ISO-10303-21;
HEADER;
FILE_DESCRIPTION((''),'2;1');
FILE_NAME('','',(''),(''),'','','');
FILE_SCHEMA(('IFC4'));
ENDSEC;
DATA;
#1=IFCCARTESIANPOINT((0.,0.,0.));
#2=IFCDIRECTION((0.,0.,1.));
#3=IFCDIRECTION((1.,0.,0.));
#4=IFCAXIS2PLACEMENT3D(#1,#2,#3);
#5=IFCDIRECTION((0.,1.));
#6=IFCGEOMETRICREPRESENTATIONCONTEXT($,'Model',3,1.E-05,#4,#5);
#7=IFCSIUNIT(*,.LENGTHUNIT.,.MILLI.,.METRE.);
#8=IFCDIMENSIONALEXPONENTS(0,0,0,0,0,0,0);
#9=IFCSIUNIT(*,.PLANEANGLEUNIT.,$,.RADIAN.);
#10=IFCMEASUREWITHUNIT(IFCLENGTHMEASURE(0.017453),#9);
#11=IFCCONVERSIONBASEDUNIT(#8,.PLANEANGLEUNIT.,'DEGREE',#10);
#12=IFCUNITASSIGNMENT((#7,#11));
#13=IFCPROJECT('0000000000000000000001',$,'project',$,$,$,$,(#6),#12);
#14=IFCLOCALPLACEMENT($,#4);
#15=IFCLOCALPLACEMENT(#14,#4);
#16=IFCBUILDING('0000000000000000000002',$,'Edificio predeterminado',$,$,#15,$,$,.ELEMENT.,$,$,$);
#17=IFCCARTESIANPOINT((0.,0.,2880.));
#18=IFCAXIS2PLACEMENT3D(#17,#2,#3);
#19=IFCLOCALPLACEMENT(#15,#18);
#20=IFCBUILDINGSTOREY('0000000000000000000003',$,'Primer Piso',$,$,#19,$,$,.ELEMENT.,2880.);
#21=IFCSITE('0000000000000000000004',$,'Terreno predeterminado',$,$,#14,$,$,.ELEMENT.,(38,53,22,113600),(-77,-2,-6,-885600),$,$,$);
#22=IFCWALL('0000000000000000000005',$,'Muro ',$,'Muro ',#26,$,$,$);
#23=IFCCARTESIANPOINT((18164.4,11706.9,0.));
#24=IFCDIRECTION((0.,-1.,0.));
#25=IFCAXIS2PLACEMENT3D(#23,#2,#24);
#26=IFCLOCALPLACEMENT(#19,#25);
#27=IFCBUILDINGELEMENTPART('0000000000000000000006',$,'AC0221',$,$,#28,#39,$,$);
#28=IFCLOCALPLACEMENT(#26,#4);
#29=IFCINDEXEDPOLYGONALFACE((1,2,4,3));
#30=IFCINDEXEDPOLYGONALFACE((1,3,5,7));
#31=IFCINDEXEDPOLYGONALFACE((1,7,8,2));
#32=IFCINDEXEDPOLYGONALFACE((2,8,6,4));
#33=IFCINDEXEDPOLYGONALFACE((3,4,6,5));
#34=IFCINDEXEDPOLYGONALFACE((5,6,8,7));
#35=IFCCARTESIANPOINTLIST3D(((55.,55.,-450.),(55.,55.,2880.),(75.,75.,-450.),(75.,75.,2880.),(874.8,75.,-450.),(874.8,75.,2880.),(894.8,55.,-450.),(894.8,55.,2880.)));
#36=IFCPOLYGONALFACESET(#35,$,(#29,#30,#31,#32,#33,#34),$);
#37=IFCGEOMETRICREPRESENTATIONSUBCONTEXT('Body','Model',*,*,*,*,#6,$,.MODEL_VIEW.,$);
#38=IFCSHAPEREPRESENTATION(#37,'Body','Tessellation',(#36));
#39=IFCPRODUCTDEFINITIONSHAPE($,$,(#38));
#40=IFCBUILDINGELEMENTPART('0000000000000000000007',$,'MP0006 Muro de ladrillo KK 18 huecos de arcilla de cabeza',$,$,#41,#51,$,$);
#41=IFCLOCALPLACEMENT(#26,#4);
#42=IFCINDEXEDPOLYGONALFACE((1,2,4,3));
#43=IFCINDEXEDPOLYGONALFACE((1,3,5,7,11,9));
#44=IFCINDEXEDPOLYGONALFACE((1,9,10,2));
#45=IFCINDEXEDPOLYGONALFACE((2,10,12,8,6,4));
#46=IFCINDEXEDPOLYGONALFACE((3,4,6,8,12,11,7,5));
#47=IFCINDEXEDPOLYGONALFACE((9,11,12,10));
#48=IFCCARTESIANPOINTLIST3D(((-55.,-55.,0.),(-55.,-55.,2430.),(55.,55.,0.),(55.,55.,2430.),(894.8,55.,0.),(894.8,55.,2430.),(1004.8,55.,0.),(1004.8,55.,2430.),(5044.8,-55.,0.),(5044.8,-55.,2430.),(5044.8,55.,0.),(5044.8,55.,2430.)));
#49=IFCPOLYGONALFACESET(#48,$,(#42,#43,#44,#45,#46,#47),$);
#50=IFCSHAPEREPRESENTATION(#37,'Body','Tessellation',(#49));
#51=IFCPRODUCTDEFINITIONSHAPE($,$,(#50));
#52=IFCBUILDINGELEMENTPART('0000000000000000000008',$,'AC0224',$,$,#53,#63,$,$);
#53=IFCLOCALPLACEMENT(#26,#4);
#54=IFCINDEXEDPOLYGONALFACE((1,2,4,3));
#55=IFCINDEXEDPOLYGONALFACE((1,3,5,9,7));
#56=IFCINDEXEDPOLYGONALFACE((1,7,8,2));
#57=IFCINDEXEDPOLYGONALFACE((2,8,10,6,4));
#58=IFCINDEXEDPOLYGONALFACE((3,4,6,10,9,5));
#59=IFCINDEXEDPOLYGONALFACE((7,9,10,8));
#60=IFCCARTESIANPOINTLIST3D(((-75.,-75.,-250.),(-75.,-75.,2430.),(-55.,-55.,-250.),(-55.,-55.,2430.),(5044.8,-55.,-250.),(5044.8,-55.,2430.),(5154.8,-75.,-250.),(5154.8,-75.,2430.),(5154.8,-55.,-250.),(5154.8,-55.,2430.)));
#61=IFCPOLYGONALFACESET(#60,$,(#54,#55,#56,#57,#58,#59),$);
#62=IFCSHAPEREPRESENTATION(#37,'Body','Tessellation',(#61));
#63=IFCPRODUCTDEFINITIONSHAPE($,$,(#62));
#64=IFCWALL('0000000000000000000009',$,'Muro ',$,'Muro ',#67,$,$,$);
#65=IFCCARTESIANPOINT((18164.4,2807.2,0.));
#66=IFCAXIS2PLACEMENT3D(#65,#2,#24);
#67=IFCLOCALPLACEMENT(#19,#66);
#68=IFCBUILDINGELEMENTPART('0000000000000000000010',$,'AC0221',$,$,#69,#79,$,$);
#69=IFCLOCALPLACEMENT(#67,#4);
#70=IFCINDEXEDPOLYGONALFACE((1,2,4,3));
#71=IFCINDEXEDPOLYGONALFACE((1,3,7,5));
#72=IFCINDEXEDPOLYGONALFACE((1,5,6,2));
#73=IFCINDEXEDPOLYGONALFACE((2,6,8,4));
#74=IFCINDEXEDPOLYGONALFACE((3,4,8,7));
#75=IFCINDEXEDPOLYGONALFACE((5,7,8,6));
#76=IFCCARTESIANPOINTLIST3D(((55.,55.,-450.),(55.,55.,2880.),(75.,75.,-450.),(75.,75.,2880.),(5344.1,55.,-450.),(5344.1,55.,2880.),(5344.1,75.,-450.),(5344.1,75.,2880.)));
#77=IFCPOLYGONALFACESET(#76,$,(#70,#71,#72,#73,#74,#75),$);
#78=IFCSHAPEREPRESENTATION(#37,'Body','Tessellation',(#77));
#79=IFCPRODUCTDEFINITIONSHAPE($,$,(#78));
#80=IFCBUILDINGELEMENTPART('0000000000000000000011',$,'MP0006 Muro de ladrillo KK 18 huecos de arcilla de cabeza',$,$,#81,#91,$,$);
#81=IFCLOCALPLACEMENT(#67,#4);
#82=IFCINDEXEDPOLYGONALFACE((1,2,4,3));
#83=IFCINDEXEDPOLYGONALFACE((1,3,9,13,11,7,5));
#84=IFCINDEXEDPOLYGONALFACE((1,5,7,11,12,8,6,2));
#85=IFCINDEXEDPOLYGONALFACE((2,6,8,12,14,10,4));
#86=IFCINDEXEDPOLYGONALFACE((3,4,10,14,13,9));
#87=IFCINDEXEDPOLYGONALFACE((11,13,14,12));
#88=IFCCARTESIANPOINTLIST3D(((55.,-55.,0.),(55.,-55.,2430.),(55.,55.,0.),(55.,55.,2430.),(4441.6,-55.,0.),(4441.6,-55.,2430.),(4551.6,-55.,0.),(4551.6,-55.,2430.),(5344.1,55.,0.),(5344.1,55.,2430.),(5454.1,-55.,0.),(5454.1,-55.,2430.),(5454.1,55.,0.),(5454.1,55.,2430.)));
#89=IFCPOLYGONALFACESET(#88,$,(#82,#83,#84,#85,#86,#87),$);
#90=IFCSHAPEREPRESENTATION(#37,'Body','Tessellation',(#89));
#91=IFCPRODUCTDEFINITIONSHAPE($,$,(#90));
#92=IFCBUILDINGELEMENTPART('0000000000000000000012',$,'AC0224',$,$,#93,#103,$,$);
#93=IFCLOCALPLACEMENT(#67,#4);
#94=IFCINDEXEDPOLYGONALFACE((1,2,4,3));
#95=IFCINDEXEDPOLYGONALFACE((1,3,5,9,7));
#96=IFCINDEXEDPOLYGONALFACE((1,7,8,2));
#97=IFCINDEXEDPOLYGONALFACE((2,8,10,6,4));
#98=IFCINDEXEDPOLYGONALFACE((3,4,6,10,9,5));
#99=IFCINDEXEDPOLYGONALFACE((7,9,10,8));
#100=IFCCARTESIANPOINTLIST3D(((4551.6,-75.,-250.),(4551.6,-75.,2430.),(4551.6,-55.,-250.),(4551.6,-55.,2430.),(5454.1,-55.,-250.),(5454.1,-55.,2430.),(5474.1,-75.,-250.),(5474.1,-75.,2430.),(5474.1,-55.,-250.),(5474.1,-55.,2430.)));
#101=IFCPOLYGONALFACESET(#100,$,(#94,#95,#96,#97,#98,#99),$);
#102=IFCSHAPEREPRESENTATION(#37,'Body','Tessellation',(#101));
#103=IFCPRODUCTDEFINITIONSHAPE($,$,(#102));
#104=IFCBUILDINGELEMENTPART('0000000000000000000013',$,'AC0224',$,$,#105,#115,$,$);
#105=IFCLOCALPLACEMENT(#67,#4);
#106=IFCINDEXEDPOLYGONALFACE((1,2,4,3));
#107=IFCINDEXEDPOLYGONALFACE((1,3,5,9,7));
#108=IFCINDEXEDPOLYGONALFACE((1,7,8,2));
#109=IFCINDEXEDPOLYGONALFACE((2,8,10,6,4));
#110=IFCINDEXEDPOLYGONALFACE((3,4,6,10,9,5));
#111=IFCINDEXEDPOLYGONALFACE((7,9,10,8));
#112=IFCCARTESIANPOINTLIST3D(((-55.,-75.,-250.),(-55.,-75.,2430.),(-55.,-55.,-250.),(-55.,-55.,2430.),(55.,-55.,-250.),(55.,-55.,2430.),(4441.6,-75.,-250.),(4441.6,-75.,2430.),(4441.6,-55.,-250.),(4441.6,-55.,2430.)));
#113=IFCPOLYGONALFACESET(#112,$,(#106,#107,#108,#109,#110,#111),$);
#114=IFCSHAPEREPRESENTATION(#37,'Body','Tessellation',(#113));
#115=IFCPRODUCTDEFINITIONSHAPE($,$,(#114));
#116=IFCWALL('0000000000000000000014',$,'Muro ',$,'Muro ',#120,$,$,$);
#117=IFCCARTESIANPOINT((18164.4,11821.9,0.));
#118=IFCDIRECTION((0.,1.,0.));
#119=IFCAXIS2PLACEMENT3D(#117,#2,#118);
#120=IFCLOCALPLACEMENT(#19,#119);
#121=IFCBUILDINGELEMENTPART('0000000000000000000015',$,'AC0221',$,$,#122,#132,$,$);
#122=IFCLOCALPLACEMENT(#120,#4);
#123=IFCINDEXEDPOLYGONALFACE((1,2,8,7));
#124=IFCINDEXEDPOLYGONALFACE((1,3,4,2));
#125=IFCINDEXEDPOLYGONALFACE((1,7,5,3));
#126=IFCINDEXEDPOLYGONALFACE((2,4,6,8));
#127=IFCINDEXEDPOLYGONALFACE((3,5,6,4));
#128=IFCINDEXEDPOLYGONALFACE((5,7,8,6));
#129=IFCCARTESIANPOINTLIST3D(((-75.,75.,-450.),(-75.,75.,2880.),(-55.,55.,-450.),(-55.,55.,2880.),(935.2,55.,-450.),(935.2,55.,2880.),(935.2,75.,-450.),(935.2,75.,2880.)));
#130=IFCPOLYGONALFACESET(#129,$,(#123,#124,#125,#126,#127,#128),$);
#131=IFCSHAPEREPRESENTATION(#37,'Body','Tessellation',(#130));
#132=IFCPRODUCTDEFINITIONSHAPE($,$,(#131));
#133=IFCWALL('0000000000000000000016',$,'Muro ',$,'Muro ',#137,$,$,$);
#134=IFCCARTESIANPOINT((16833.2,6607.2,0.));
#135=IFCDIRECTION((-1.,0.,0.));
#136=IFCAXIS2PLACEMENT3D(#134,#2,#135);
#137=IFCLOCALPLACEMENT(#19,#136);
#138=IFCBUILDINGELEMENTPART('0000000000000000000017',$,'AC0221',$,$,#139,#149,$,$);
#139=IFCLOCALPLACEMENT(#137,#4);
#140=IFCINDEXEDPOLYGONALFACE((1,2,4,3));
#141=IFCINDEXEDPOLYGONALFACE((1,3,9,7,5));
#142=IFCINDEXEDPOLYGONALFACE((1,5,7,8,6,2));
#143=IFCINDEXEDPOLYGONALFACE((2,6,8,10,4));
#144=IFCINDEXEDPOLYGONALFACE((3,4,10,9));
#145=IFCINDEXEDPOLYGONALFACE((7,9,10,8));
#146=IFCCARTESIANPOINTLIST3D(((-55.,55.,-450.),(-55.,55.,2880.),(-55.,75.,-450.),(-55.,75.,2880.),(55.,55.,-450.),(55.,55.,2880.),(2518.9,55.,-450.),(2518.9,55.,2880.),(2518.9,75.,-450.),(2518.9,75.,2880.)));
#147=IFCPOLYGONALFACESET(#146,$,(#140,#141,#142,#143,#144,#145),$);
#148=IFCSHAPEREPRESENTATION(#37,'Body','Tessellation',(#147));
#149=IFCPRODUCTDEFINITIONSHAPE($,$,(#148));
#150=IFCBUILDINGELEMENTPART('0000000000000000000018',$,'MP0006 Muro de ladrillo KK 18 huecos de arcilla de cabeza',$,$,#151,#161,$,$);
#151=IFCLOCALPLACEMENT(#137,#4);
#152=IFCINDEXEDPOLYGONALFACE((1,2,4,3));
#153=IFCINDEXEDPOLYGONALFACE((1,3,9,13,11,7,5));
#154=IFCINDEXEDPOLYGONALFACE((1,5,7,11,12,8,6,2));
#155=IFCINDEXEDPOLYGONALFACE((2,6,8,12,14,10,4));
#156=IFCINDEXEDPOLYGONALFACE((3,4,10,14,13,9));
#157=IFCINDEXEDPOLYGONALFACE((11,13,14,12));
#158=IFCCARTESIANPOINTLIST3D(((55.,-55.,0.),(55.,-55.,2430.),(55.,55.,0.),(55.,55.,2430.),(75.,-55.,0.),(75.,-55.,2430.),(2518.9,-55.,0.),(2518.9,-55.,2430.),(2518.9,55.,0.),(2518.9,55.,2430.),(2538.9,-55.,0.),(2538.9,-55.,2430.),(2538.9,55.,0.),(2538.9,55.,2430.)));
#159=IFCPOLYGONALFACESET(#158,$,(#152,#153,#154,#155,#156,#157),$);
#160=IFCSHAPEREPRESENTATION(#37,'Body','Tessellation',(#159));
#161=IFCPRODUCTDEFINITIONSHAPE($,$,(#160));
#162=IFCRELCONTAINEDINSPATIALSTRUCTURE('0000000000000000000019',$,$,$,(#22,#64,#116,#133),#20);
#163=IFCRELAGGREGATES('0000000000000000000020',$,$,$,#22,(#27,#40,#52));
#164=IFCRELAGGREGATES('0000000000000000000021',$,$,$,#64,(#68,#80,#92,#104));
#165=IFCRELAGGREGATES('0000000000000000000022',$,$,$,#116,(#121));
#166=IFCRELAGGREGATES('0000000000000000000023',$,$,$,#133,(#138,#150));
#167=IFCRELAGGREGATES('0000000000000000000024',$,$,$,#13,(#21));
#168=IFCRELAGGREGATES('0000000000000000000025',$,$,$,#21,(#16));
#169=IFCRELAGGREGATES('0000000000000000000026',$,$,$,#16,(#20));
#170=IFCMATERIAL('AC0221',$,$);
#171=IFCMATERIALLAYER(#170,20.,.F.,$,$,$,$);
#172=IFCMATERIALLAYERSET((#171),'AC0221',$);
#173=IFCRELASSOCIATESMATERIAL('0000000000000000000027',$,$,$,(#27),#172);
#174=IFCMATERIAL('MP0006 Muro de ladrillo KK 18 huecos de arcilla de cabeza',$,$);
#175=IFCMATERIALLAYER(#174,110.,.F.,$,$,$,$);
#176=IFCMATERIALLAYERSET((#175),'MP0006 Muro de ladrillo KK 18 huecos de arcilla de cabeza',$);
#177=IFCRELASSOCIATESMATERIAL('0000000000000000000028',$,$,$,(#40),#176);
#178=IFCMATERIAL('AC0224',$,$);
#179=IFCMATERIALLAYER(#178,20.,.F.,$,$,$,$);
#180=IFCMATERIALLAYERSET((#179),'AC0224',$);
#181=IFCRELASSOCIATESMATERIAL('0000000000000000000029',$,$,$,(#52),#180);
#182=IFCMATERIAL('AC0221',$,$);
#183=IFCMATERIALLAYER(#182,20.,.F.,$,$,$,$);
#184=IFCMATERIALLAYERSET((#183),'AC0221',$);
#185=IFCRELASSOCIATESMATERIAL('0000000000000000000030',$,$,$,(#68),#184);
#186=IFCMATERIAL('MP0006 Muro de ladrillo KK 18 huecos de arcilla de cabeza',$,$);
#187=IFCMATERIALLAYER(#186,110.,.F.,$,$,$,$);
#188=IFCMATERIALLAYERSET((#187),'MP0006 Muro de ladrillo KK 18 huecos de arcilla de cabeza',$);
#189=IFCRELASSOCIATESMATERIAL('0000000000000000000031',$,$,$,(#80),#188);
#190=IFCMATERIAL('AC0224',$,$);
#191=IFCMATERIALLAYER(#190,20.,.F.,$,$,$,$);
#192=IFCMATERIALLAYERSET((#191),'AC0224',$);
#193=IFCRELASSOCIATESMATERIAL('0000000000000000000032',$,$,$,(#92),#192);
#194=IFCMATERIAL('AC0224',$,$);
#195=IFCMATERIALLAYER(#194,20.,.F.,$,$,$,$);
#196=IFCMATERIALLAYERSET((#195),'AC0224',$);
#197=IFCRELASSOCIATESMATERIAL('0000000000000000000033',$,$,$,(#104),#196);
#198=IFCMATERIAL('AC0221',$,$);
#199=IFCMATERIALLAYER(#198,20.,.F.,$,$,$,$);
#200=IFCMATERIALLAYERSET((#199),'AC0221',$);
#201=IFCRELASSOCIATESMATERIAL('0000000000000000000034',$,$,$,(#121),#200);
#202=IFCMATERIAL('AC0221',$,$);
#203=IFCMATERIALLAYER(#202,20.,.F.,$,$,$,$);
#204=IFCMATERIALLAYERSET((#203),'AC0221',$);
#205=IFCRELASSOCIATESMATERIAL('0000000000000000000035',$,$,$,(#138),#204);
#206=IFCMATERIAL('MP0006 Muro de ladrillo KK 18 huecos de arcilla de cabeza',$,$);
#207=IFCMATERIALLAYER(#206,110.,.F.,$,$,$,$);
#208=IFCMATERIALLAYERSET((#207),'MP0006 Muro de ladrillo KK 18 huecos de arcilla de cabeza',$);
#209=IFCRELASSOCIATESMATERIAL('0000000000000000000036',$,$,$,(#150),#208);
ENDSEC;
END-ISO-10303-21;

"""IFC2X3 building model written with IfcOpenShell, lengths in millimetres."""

from ifc_helpers import new_model, entity, si_unit, converted_unit, direction, frame, origin_with_axes, place, context, subcontext, project, spatial, polyline, outline, extrude, material, layer, layer_set, layer_usage, element, aggregate, save


model = new_model("IFC2X3")

# Units and contexts
model_context = context("Model", 3, precision=1e-05, world=origin_with_axes(), true_north=direction((0.0, 1.0)))
body_context = subcontext(model_context, "Body", "Model", "MODEL_VIEW")
ifc_project = project(units=[si_unit("LENGTHUNIT", "METRE", prefix="MILLI"), converted_unit("PLANEANGLEUNIT", "DEGREE", entity("IfcLengthMeasure", 0.017453), si_unit("PLANEANGLEUNIT", "RADIAN"), dimensions=[0, 0, 0, 0, 0, 0, 0])], contexts=[model_context])

# Site, building, storey
site_placement = place(None, origin_with_axes())
site = spatial("IfcSite", under=ifc_project, at=site_placement, Name="Terreno predeterminado", CompositionType="ELEMENT", RefLatitude=(38, 53, 22, 113600), RefLongitude=(-77, -2, -6, -885600))
building_placement = place(site_placement, origin_with_axes())
building = spatial("IfcBuilding", under=site, at=building_placement, Name="Edificio predeterminado", CompositionType="ELEMENT")
storey_placement = place(building_placement, frame((0.0, 0.0, 2880.0), z_axis=(0.0, 0.0, 1.0), x_axis=(1.0, 0.0, 0.0)))
storey = spatial("IfcBuildingStorey", under=building, at=storey_placement, Name="Primer Piso", CompositionType="ELEMENT", Elevation=2880.0)

# Walls, building element parts
wall_1_placement = place(storey_placement, frame((18164.4, 11706.9, 0.0), z_axis=(0.0, 0.0, 1.0), x_axis=(0.0, -1.0, 0.0)))
wall_1 = element("IfcWall", 1, at=wall_1_placement, inside=storey, Name="Muro ", ObjectType="Muro ")
ifc_material_1 = material(Name="AC0221")
ifc_layer_1 = layer(ifc_material_1, 20.0, ventilated=False)
ifc_layer_set_1 = layer_set([ifc_layer_1], Name="AC0221")
ifc_layer_usage_1 = layer_usage(ifc_layer_set_1, "AXIS2", "NEGATIVE", -75.0)
building_element_part_1_placement = place(wall_1_placement, origin_with_axes())
building_element_part_1 = element("IfcBuildingElementPart", 2, at=building_element_part_1_placement, material=ifc_layer_usage_1, Name="AC0221", context=body_context, shape_type="SweptSolid", body=[
    extrude(outline(polyline([(874.8, 75.0), (894.8, 55.0), (55.0, 55.0), (75.0, 75.0), (874.8, 75.0)])), frame((0.0, 0.0, -450.0), z_axis=(0.0, 0.0, 1.0), x_axis=(1.0, 0.0, 0.0)), (0.0, 0.0, 1.0), 3330.0),
])
ifc_material_2 = material(Name="MP0006 Muro de ladrillo KK 18 huecos de arcilla de cabeza")
ifc_layer_2 = layer(ifc_material_2, 110.0, ventilated=False)
ifc_layer_set_2 = layer_set([ifc_layer_2], Name="MP0006 Muro de ladrillo KK 18 huecos de arcilla de cabeza")
ifc_layer_usage_2 = layer_usage(ifc_layer_set_2, "AXIS2", "NEGATIVE", -55.0)
building_element_part_2_placement = place(wall_1_placement, origin_with_axes())
building_element_part_2 = element("IfcBuildingElementPart", 3, at=building_element_part_2_placement, material=ifc_layer_usage_2, Name="MP0006 Muro de ladrillo KK 18 huecos de arcilla de cabeza", context=body_context, shape_type="SweptSolid", body=[
    extrude(outline(polyline([(5044.8, 55.0), (5044.8, -55.0), (-55.0, -55.0), (55.0, 55.0), (894.8, 55.0), (1004.8, 55.0), (5044.8, 55.0)])), origin_with_axes(), (0.0, 0.0, 1.0), 2430.0),
])
ifc_material_3 = material(Name="AC0224")
ifc_layer_3 = layer(ifc_material_3, 20.0, ventilated=False)
ifc_layer_set_3 = layer_set([ifc_layer_3], Name="AC0224")
ifc_layer_usage_3 = layer_usage(ifc_layer_set_3, "AXIS2", "NEGATIVE", 55.0)
building_element_part_3_placement = place(wall_1_placement, origin_with_axes())
building_element_part_3 = element("IfcBuildingElementPart", 4, at=building_element_part_3_placement, material=ifc_layer_usage_3, Name="AC0224", context=body_context, shape_type="SweptSolid", body=[
    extrude(outline(polyline([(5154.8, -55.0), (5154.8, -75.0), (-75.0, -75.0), (-55.0, -55.0), (5044.8, -55.0), (5154.8, -55.0)])), frame((0.0, 0.0, -250.0), z_axis=(0.0, 0.0, 1.0), x_axis=(1.0, 0.0, 0.0)), (0.0, 0.0, 1.0), 2680.0),
])
aggregate(wall_1, [building_element_part_1, building_element_part_2, building_element_part_3])
wall_2_placement = place(storey_placement, frame((18164.4, 2807.2, 0.0), z_axis=(0.0, 0.0, 1.0), x_axis=(0.0, -1.0, 0.0)))
wall_2 = element("IfcWall", 5, at=wall_2_placement, inside=storey, Name="Muro ", ObjectType="Muro ")
ifc_material_4 = material(Name="AC0221")
ifc_layer_4 = layer(ifc_material_4, 20.0, ventilated=False)
ifc_layer_set_4 = layer_set([ifc_layer_4], Name="AC0221")
ifc_layer_usage_4 = layer_usage(ifc_layer_set_4, "AXIS2", "NEGATIVE", -75.0)
building_element_part_4_placement = place(wall_2_placement, origin_with_axes())
building_element_part_4 = element("IfcBuildingElementPart", 6, at=building_element_part_4_placement, material=ifc_layer_usage_4, Name="AC0221", context=body_context, shape_type="SweptSolid", body=[
    extrude(outline(polyline([(5344.1, 75.0), (5344.1, 55.0), (55.0, 55.0), (75.0, 75.0), (5344.1, 75.0)])), frame((0.0, 0.0, -450.0), z_axis=(0.0, 0.0, 1.0), x_axis=(1.0, 0.0, 0.0)), (0.0, 0.0, 1.0), 3330.0),
])
ifc_material_5 = material(Name="MP0006 Muro de ladrillo KK 18 huecos de arcilla de cabeza")
ifc_layer_5 = layer(ifc_material_5, 110.0, ventilated=False)
ifc_layer_set_5 = layer_set([ifc_layer_5], Name="MP0006 Muro de ladrillo KK 18 huecos de arcilla de cabeza")
ifc_layer_usage_5 = layer_usage(ifc_layer_set_5, "AXIS2", "NEGATIVE", -55.0)
building_element_part_5_placement = place(wall_2_placement, origin_with_axes())
building_element_part_5 = element("IfcBuildingElementPart", 7, at=building_element_part_5_placement, material=ifc_layer_usage_5, Name="MP0006 Muro de ladrillo KK 18 huecos de arcilla de cabeza", context=body_context, shape_type="SweptSolid", body=[
    extrude(outline(polyline([(5454.1, 55.0), (5454.1, -55.0), (4551.6, -55.0), (4441.6, -55.0), (55.0, -55.0), (55.0, 55.0), (5344.1, 55.0), (5454.1, 55.0)])), origin_with_axes(), (0.0, 0.0, 1.0), 2430.0),
])
ifc_material_6 = material(Name="AC0224")
ifc_layer_6 = layer(ifc_material_6, 20.0, ventilated=False)
ifc_layer_set_6 = layer_set([ifc_layer_6], Name="AC0224")
ifc_layer_usage_6 = layer_usage(ifc_layer_set_6, "AXIS2", "NEGATIVE", 55.0)
building_element_part_6_placement = place(wall_2_placement, origin_with_axes())
building_element_part_6 = element("IfcBuildingElementPart", 8, at=building_element_part_6_placement, material=ifc_layer_usage_6, Name="AC0224", context=body_context, shape_type="SweptSolid", body=[
    extrude(outline(polyline([(5474.1, -55.0), (5474.1, -75.0), (4551.6, -75.0), (4551.6, -55.0), (5454.1, -55.0), (5474.1, -55.0)])), frame((0.0, 0.0, -250.0), z_axis=(0.0, 0.0, 1.0), x_axis=(1.0, 0.0, 0.0)), (0.0, 0.0, 1.0), 2680.0),
])
ifc_material_7 = material(Name="AC0224")
ifc_layer_7 = layer(ifc_material_7, 20.0, ventilated=False)
ifc_layer_set_7 = layer_set([ifc_layer_7], Name="AC0224")
ifc_layer_usage_7 = layer_usage(ifc_layer_set_7, "AXIS2", "NEGATIVE", 55.0)
building_element_part_7_placement = place(wall_2_placement, origin_with_axes())
building_element_part_7 = element("IfcBuildingElementPart", 9, at=building_element_part_7_placement, material=ifc_layer_usage_7, Name="AC0224", context=body_context, shape_type="SweptSolid", body=[
    extrude(outline(polyline([(4441.6, -55.0), (4441.6, -75.0), (-55.0, -75.0), (-55.0, -55.0), (55.0, -55.0), (4441.6, -55.0)])), frame((0.0, 0.0, -250.0), z_axis=(0.0, 0.0, 1.0), x_axis=(1.0, 0.0, 0.0)), (0.0, 0.0, 1.0), 2680.0),
])
aggregate(wall_2, [building_element_part_4, building_element_part_5, building_element_part_6, building_element_part_7])

# Wall, building element part
wall_3_placement = place(storey_placement, frame((18164.4, 11821.9, 0.0), z_axis=(0.0, 0.0, 1.0), x_axis=(0.0, 1.0, 0.0)))
wall_3 = element("IfcWall", 10, at=wall_3_placement, inside=storey, Name="Muro ", ObjectType="Muro ")
ifc_material_8 = material(Name="AC0221")
ifc_layer_8 = layer(ifc_material_8, 20.0, ventilated=False)
ifc_layer_set_8 = layer_set([ifc_layer_8], Name="AC0221")
ifc_layer_usage_8 = layer_usage(ifc_layer_set_8, "AXIS2", "NEGATIVE", -75.0)
building_element_part_8_placement = place(wall_3_placement, origin_with_axes())
building_element_part_8 = element("IfcBuildingElementPart", 11, at=building_element_part_8_placement, material=ifc_layer_usage_8, Name="AC0221", context=body_context, shape_type="SweptSolid", body=[
    extrude(outline(polyline([(935.2, 75.0), (935.2, 55.0), (-55.0, 55.0), (-75.0, 75.0), (935.2, 75.0)])), frame((0.0, 0.0, -450.0), z_axis=(0.0, 0.0, 1.0), x_axis=(1.0, 0.0, 0.0)), (0.0, 0.0, 1.0), 3330.0),
])
aggregate(wall_3, [building_element_part_8])

# Wall, building element parts
wall_4_placement = place(storey_placement, frame((16833.2, 6607.2, 0.0), z_axis=(0.0, 0.0, 1.0), x_axis=(-1.0, 0.0, 0.0)))
wall_4 = element("IfcWall", 12, at=wall_4_placement, inside=storey, Name="Muro ", ObjectType="Muro ")
ifc_material_9 = material(Name="AC0221")
ifc_layer_9 = layer(ifc_material_9, 20.0, ventilated=False)
ifc_layer_set_9 = layer_set([ifc_layer_9], Name="AC0221")
ifc_layer_usage_9 = layer_usage(ifc_layer_set_9, "AXIS2", "NEGATIVE", -75.0)
building_element_part_9_placement = place(wall_4_placement, origin_with_axes())
building_element_part_9 = element("IfcBuildingElementPart", 13, at=building_element_part_9_placement, material=ifc_layer_usage_9, Name="AC0221", context=body_context, shape_type="SweptSolid", body=[
    extrude(outline(polyline([(2518.9, 75.0), (2518.9, 55.0), (55.0, 55.0), (-55.0, 55.0), (-55.0, 75.0), (2518.9, 75.0)])), frame((0.0, 0.0, -450.0), z_axis=(0.0, 0.0, 1.0), x_axis=(1.0, 0.0, 0.0)), (0.0, 0.0, 1.0), 3330.0),
])
ifc_material_10 = material(Name="MP0006 Muro de ladrillo KK 18 huecos de arcilla de cabeza")
ifc_layer_10 = layer(ifc_material_10, 110.0, ventilated=False)
ifc_layer_set_10 = layer_set([ifc_layer_10], Name="MP0006 Muro de ladrillo KK 18 huecos de arcilla de cabeza")
ifc_layer_usage_10 = layer_usage(ifc_layer_set_10, "AXIS2", "NEGATIVE", -55.0)
building_element_part_10_placement = place(wall_4_placement, origin_with_axes())
building_element_part_10 = element("IfcBuildingElementPart", 14, at=building_element_part_10_placement, material=ifc_layer_usage_10, Name="MP0006 Muro de ladrillo KK 18 huecos de arcilla de cabeza", context=body_context, shape_type="SweptSolid", body=[
    extrude(outline(polyline([(2538.9, 55.0), (2538.9, -55.0), (2518.9, -55.0), (75.0, -55.0), (55.0, -55.0), (55.0, 55.0), (2518.9, 55.0), (2538.9, 55.0)])), origin_with_axes(), (0.0, 0.0, 1.0), 2430.0),
])
aggregate(wall_4, [building_element_part_9, building_element_part_10])

save(model, "model.ifc")
